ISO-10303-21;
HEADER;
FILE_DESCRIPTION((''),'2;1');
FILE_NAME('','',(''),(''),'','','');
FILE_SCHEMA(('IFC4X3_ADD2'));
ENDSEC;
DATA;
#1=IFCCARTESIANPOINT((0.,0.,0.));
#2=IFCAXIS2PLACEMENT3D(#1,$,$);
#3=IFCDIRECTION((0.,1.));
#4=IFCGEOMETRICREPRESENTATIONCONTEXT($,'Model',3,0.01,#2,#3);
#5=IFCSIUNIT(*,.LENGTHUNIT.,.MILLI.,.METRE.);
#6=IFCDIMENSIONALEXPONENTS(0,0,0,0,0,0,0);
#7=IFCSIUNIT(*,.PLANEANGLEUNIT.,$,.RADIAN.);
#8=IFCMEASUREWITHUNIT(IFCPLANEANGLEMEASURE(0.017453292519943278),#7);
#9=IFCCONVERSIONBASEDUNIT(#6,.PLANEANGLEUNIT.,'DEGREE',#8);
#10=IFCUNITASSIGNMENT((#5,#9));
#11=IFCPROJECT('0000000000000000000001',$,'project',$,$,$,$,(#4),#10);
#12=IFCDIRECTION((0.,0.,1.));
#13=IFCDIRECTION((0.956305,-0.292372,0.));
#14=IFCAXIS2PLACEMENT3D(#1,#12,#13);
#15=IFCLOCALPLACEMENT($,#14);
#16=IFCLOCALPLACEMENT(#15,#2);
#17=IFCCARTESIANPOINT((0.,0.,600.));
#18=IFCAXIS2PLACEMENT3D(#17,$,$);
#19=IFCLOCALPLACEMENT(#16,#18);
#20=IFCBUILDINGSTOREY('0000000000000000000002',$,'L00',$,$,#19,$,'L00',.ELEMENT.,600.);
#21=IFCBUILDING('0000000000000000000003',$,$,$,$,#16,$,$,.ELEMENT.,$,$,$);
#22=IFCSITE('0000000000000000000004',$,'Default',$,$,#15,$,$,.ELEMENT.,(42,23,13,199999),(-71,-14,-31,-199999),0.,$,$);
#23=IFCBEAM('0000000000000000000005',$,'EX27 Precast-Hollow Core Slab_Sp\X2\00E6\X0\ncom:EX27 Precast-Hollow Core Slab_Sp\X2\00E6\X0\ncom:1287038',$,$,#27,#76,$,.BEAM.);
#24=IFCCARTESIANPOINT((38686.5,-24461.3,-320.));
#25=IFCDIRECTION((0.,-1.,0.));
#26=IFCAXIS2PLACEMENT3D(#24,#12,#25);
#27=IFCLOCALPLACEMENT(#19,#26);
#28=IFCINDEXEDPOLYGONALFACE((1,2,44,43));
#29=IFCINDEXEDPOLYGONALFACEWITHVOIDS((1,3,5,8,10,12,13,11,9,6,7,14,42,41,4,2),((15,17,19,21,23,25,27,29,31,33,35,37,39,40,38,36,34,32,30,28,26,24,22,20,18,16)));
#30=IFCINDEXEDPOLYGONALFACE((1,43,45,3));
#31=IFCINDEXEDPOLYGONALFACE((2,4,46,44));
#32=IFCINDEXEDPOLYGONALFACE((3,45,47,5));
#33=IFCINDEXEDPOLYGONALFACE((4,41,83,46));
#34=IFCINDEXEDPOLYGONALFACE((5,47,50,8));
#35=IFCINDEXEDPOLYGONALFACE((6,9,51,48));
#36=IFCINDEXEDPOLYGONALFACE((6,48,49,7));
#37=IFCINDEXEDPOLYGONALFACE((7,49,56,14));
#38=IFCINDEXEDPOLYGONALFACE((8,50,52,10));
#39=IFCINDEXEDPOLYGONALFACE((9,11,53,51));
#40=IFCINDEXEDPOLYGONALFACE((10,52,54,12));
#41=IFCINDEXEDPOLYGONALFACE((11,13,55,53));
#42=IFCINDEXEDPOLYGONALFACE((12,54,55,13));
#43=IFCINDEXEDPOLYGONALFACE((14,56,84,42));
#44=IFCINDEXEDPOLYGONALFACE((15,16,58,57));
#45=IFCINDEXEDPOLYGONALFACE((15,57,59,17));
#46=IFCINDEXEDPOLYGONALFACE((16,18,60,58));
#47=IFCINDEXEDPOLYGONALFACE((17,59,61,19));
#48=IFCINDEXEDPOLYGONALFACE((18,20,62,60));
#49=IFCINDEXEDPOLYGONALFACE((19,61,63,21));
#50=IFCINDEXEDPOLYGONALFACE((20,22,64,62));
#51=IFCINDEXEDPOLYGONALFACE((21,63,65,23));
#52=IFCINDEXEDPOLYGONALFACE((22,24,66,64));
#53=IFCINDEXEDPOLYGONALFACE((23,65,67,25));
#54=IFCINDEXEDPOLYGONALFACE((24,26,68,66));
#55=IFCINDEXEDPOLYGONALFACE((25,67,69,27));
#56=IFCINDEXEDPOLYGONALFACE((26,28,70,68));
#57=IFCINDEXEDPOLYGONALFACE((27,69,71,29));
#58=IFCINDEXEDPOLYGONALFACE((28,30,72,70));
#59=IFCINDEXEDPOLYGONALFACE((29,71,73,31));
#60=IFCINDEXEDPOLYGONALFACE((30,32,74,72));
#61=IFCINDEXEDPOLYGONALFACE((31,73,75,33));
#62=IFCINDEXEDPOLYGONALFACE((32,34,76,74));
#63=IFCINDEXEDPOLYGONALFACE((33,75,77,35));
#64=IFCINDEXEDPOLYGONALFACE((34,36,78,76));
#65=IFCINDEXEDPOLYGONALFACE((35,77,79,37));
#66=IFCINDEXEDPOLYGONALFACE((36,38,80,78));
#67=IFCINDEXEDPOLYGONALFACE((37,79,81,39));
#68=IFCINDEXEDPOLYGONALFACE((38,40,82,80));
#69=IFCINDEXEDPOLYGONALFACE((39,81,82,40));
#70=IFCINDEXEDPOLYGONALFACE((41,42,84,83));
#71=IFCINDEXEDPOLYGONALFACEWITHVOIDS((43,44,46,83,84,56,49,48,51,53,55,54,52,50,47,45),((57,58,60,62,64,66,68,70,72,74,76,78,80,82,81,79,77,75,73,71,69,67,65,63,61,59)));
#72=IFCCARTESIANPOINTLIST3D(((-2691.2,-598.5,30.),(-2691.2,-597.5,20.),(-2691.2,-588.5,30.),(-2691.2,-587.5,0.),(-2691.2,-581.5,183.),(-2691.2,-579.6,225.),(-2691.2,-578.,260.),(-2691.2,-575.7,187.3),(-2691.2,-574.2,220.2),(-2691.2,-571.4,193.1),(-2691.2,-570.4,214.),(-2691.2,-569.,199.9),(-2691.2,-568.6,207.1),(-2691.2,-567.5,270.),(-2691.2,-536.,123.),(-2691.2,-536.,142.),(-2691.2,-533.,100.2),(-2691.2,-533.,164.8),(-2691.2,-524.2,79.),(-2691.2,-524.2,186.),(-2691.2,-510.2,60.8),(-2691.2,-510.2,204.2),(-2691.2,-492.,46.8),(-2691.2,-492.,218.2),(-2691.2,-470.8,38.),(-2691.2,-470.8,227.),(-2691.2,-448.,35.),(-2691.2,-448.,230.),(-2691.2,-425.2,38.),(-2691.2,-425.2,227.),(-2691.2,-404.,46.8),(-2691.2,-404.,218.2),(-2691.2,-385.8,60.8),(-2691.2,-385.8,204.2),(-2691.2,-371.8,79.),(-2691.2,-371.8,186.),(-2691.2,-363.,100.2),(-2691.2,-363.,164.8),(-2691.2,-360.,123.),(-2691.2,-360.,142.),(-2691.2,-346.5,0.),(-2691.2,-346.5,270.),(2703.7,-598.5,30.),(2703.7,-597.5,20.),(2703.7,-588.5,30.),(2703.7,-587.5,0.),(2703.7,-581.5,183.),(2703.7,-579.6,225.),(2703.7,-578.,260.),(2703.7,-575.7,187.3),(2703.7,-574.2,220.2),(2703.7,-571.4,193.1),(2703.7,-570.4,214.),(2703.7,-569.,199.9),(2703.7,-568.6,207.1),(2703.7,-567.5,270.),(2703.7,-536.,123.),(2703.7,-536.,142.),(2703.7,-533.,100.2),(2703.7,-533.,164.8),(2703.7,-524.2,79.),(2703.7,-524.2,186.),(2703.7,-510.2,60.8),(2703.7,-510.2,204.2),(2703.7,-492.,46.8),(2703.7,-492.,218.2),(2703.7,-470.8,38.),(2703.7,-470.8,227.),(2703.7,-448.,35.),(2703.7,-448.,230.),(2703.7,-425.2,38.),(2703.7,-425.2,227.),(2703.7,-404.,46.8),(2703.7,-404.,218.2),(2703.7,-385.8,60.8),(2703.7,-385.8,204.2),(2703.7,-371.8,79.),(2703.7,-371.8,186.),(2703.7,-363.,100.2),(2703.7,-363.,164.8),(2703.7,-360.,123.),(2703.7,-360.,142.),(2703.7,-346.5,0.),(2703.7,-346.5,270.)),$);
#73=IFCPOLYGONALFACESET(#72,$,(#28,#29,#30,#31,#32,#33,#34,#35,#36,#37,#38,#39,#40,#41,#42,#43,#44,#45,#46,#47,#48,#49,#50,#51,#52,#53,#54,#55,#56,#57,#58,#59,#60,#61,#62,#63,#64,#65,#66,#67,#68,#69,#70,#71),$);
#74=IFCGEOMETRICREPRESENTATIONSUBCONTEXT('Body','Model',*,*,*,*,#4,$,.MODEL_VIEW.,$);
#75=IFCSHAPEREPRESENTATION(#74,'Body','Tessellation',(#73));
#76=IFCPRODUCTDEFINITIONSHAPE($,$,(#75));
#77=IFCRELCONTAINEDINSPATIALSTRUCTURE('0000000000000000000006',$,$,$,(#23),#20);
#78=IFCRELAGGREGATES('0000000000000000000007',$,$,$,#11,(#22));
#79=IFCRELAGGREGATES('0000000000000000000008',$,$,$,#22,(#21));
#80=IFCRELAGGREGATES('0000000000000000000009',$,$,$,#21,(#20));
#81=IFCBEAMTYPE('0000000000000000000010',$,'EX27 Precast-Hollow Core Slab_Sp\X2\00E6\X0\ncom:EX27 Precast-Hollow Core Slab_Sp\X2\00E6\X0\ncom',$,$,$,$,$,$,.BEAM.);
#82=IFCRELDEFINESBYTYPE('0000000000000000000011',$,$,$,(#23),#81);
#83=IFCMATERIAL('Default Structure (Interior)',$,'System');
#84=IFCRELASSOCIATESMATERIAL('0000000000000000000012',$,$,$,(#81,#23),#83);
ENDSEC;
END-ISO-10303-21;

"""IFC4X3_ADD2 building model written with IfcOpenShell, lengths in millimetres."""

from ifc_helpers import new_model, entity, si_unit, converted_unit, direction, frame, frame_2d, origin, place, context, subcontext, project, spatial, polyline, circle_curve, parameter, trimmed, segment, composite_curve, outline, extrude, source, transform, mapped, material, material_profile, profile_set, profile_usage, type_object, type_shapes, element, save


model = new_model("IFC4X3_ADD2")

# Units and contexts
model_context = context("Model", 3, precision=0.01, world=origin(), true_north=direction((0.0, 1.0)))
body_context = subcontext(model_context, "Body", "Model", "MODEL_VIEW")
ifc_project = project(units=[si_unit("LENGTHUNIT", "METRE", prefix="MILLI"), converted_unit("PLANEANGLEUNIT", "DEGREE", entity("IfcPlaneAngleMeasure", 0.017453292519943278), si_unit("PLANEANGLEUNIT", "RADIAN"), dimensions=[0, 0, 0, 0, 0, 0, 0])], contexts=[model_context])

# Site, building, storey
site_placement = place(None, frame((0.0, 0.0, 0.0), z_axis=(0.0, 0.0, 1.0), x_axis=(0.956305, -0.292372, 0.0)))
site = spatial("IfcSite", under=ifc_project, at=site_placement, Name="Default", CompositionType="ELEMENT", RefLatitude=(42, 23, 13, 199999), RefLongitude=(-71, -14, -31, -199999), RefElevation=0.0)
building_placement = place(site_placement, origin())
building = spatial("IfcBuilding", under=site, at=building_placement, CompositionType="ELEMENT")
storey_placement = place(building_placement, frame((0.0, 0.0, 600.0)))
storey = spatial("IfcBuildingStorey", under=building, at=storey_placement, Name="L00", LongName="L00", CompositionType="ELEMENT", Elevation=600.0)

# Beam
ifc_material_1 = material(Name="Default Structure (Interior)", Category="System")
ifc_material_profile_1 = material_profile(ifc_material_1, outline(composite_curve([segment(polyline([(-124.1, 583.4), (-124.6, 593.4)]), True, "CONTINUOUS"), segment(polyline([(-124.6, 593.4), (-134.5, 592.0)]), True, "CONTINUOUS"), segment(polyline([(-134.5, 592.0), (-154.0, 581.1)]), True, "CONTINUOUS"), segment(polyline([(-154.0, 581.1), (-100.2, -592.7)]), True, "CONTINUOUS"), segment(polyline([(-100.2, -592.7), (-79.8, -601.8)]), True, "CONTINUOUS"), segment(polyline([(-79.8, -601.8), (-69.7, -602.3)]), True, "CONTINUOUS"), segment(polyline([(-69.7, -602.3), (-70.2, -592.3)]), True, "CONTINUOUS"), segment(polyline([(-70.2, -592.3), (82.3, -578.3)]), True, "CONTINUOUS"), segment(trimmed(circle_curve(frame_2d((104.4, -588.8), x_axis=(0.045785, -0.998951)), 24.4), [parameter(123.160759)], [parameter(242.087681)], True, "PARAMETER"), False, "CONTINUOUS"), segment(polyline([(124.2, -574.5), (159.1, -571.3)]), True, "CONTINUOUS"), segment(polyline([(159.1, -571.3), (168.6, -560.4)]), True, "CONTINUOUS"), segment(polyline([(168.6, -560.4), (116.6, 573.4)]), True, "CONTINUOUS"), segment(polyline([(116.6, 573.4), (106.2, 583.4)]), True, "CONTINUOUS"), segment(polyline([(106.2, 583.4), (71.1, 583.4)]), True, "CONTINUOUS"), segment(trimmed(circle_curve(frame_2d((50.1, 595.8), x_axis=(0.045785, -0.998951)), 24.4), [parameter(297.912319)], [parameter(56.839241)], True, "PARAMETER"), False, "CONTINUOUS"), segment(polyline([(29.1, 583.4), (-124.1, 583.4)]), True, "CONTINUOUS")], self_intersect=False), holes=[composite_curve([segment(polyline([(39.3, -534.8), (20.3, -535.6)]), True, "CONTINUOUS"), segment(trimmed(circle_curve(frame_2d((16.3, -447.7), x_axis=(0.045785, -0.998951)), 88.0), [parameter(270.0)], [parameter(0.0)], True, "PARAMETER"), False, "CONTINUOUS"), segment(trimmed(circle_curve(frame_2d((16.3, -447.7), x_axis=(0.045785, -0.998951)), 88.0), [parameter(180.0)], [parameter(270.0)], True, "PARAMETER"), False, "CONTINUOUS"), segment(polyline([(12.2, -359.8), (31.2, -358.9)]), True, "CONTINUOUS"), segment(trimmed(circle_curve(frame_2d((35.2, -446.9), x_axis=(0.045785, -0.998951)), 88.0), [parameter(90.0)], [parameter(180.0)], True, "PARAMETER"), False, "CONTINUOUS"), segment(trimmed(circle_curve(frame_2d((35.2, -446.9), x_axis=(0.045785, -0.998951)), 88.0), [parameter(0.0)], [parameter(90.0)], True, "PARAMETER"), False, "CONTINUOUS")], self_intersect=False), composite_curve([segment(trimmed(circle_curve(frame_2d((6.0, -224.0), x_axis=(0.045785, -0.998951)), 88.0), [parameter(180.0)], [parameter(270.0)], True, "PARAMETER"), False, "CONTINUOUS"), segment(polyline([(2.0, -136.1), (21.0, -135.2)]), True, "CONTINUOUS"), segment(trimmed(circle_curve(frame_2d((25.0, -223.1), x_axis=(0.045785, -0.998951)), 88.0), [parameter(90.0)], [parameter(180.0)], True, "PARAMETER"), False, "CONTINUOUS"), segment(trimmed(circle_curve(frame_2d((25.0, -223.1), x_axis=(0.045785, -0.998951)), 88.0), [parameter(0.0)], [parameter(90.0)], True, "PARAMETER"), False, "CONTINUOUS"), segment(polyline([(29.0, -311.0), (10.0, -311.9)]), True, "CONTINUOUS"), segment(trimmed(circle_curve(frame_2d((6.0, -224.0), x_axis=(0.045785, -0.998951)), 88.0), [parameter(270.0)], [parameter(0.0)], True, "PARAMETER"), False, "CONTINUOUS")], self_intersect=False), composite_curve([segment(trimmed(circle_curve(frame_2d((-4.2, -0.2), x_axis=(0.045785, -0.998951)), 88.0), [parameter(180.0)], [parameter(270.0)], True, "PARAMETER"), False, "CONTINUOUS"), segment(polyline([(-8.3, 87.7), (10.7, 88.6)]), True, "CONTINUOUS"), segment(trimmed(circle_curve(frame_2d((14.7, 0.7), x_axis=(0.045785, -0.998951)), 88.0), [parameter(90.0)], [parameter(180.0)], True, "PARAMETER"), False, "CONTINUOUS"), segment(trimmed(circle_curve(frame_2d((14.7, 0.7), x_axis=(0.045785, -0.998951)), 88.0), [parameter(0.0)], [parameter(90.0)], True, "PARAMETER"), False, "CONTINUOUS"), segment(polyline([(18.8, -87.2), (-0.2, -88.1)]), True, "CONTINUOUS"), segment(trimmed(circle_curve(frame_2d((-4.2, -0.2), x_axis=(0.045785, -0.998951)), 88.0), [parameter(270.0)], [parameter(0.0)], True, "PARAMETER"), False, "CONTINUOUS")], self_intersect=False), composite_curve([segment(trimmed(circle_curve(frame_2d((-14.5, 223.6), x_axis=(0.045785, -0.998951)), 88.0), [parameter(180.0)], [parameter(270.0)], True, "PARAMETER"), False, "CONTINUOUS"), segment(polyline([(-18.5, 311.5), (0.4, 312.3)]), True, "CONTINUOUS"), segment(trimmed(circle_curve(frame_2d((4.5, 224.4), x_axis=(0.045785, -0.998951)), 88.0), [parameter(90.0)], [parameter(180.0)], True, "PARAMETER"), False, "CONTINUOUS"), segment(trimmed(circle_curve(frame_2d((4.5, 224.4), x_axis=(0.045785, -0.998951)), 88.0), [parameter(0.0)], [parameter(90.0)], True, "PARAMETER"), False, "CONTINUOUS"), segment(polyline([(8.5, 136.5), (-10.5, 135.7)]), True, "CONTINUOUS"), segment(trimmed(circle_curve(frame_2d((-14.5, 223.6), x_axis=(0.045785, -0.998951)), 88.0), [parameter(270.0)], [parameter(0.0)], True, "PARAMETER"), False, "CONTINUOUS")], self_intersect=False), composite_curve([segment(trimmed(circle_curve(frame_2d((-24.8, 447.3), x_axis=(0.045785, -0.998951)), 88.0), [parameter(180.0)], [parameter(270.0)], True, "PARAMETER"), False, "CONTINUOUS"), segment(polyline([(-28.8, 535.2), (-9.8, 536.1)]), True, "CONTINUOUS"), segment(trimmed(circle_curve(frame_2d((-5.8, 448.2), x_axis=(0.045785, -0.998951)), 88.0), [parameter(90.0)], [parameter(180.0)], True, "PARAMETER"), False, "CONTINUOUS"), segment(trimmed(circle_curve(frame_2d((-5.8, 448.2), x_axis=(0.045785, -0.998951)), 88.0), [parameter(0.0)], [parameter(90.0)], True, "PARAMETER"), False, "CONTINUOUS"), segment(polyline([(-1.7, 360.3), (-20.7, 359.4)]), True, "CONTINUOUS"), segment(trimmed(circle_curve(frame_2d((-24.8, 447.3), x_axis=(0.045785, -0.998951)), 88.0), [parameter(270.0)], [parameter(0.0)], True, "PARAMETER"), False, "CONTINUOUS")], self_intersect=False)]), Name="EX27 Precast-Hollow Core Slab_Spæncom")
ifc_profile_set_1 = profile_set([ifc_material_profile_1], Name="EX27 Precast-Hollow Core Slab_Spæncom")
ifc_profile_usage_1 = profile_usage(ifc_profile_set_1, cardinal=8)
beam_type_1 = type_object("IfcBeamType", Name="EX27 Precast-Hollow Core Slab_Spæncom:EX27 Precast-Hollow Core Slab_Spæncom", PredefinedType="BEAM", material=ifc_profile_set_1)
shared_shape_1 = source(origin(), body_context, "Body", "SweptSolid", [
    extrude(outline(composite_curve([segment(polyline([(-50.3, -128.8), (190.7, -128.8)]), True, "CONTINUOUS"), segment(polyline([(190.7, -128.8), (190.7, 141.2)]), True, "CONTINUOUS"), segment(polyline([(190.7, 141.2), (-30.3, 141.2)]), True, "CONTINUOUS"), segment(polyline([(-30.3, 141.2), (-40.8, 131.2)]), True, "CONTINUOUS"), segment(polyline([(-40.8, 131.2), (-42.4, 96.2)]), True, "CONTINUOUS"), segment(trimmed(circle_curve(frame_2d((-55.8, 75.8), x_axis=(-1.0, 0.0)), 24.4), [parameter(117.912319)], [parameter(236.839241)], True, "PARAMETER"), False, "CONTINUOUS"), segment(polyline([(-44.3, 54.2), (-51.3, -98.8)]), True, "CONTINUOUS"), segment(polyline([(-51.3, -98.8), (-61.3, -98.8)]), True, "CONTINUOUS"), segment(polyline([(-61.3, -98.8), (-60.3, -108.8)]), True, "CONTINUOUS"), segment(polyline([(-60.3, -108.8), (-50.3, -128.8)]), True, "CONTINUOUS")], self_intersect=False), holes=[composite_curve([segment(trimmed(circle_curve(frame_2d((89.2, 13.2), x_axis=(-1.0, 0.0)), 88.0), [parameter(270.0)], [parameter(0.0)], True, "PARAMETER"), False, "CONTINUOUS"), segment(trimmed(circle_curve(frame_2d((89.2, 13.2), x_axis=(-1.0, 0.0)), 88.0), [parameter(180.0)], [parameter(270.0)], True, "PARAMETER"), False, "CONTINUOUS"), segment(polyline([(177.2, 13.2), (177.2, -5.8)]), True, "CONTINUOUS"), segment(trimmed(circle_curve(frame_2d((89.2, -5.8), x_axis=(-1.0, 0.0)), 88.0), [parameter(90.0)], [parameter(180.0)], True, "PARAMETER"), False, "CONTINUOUS"), segment(trimmed(circle_curve(frame_2d((89.2, -5.8), x_axis=(-1.0, 0.0)), 88.0), [parameter(0.0)], [parameter(90.0)], True, "PARAMETER"), False, "CONTINUOUS"), segment(polyline([(1.2, -5.8), (1.2, 13.2)]), True, "CONTINUOUS")], self_intersect=False)]), frame((-2691.2, -537.2, 128.8), z_axis=(1.0, 0.0, 0.0), x_axis=(0.0, 1.0, 0.0)), (0.0, 0.0, 1.0), 5395.0),
])
type_shapes(beam_type_1, [shared_shape_1])
beam_1_placement = place(storey_placement, frame((38686.5, -24461.3, -320.0), z_axis=(0.0, 0.0, 1.0), x_axis=(0.0, -1.0, 0.0)))
element("IfcBeam", 1, at=beam_1_placement, inside=storey, type_object=beam_type_1, material=ifc_profile_usage_1, Name="EX27 Precast-Hollow Core Slab_Spæncom:EX27 Precast-Hollow Core Slab_Spæncom:1287038", PredefinedType="BEAM", context=body_context, shape_type="MappedRepresentation", body=[
    mapped(shared_shape_1, transform((0.0, 0.0, 0.0), scale=1.0)),
])

save(model, "model.ifc")
